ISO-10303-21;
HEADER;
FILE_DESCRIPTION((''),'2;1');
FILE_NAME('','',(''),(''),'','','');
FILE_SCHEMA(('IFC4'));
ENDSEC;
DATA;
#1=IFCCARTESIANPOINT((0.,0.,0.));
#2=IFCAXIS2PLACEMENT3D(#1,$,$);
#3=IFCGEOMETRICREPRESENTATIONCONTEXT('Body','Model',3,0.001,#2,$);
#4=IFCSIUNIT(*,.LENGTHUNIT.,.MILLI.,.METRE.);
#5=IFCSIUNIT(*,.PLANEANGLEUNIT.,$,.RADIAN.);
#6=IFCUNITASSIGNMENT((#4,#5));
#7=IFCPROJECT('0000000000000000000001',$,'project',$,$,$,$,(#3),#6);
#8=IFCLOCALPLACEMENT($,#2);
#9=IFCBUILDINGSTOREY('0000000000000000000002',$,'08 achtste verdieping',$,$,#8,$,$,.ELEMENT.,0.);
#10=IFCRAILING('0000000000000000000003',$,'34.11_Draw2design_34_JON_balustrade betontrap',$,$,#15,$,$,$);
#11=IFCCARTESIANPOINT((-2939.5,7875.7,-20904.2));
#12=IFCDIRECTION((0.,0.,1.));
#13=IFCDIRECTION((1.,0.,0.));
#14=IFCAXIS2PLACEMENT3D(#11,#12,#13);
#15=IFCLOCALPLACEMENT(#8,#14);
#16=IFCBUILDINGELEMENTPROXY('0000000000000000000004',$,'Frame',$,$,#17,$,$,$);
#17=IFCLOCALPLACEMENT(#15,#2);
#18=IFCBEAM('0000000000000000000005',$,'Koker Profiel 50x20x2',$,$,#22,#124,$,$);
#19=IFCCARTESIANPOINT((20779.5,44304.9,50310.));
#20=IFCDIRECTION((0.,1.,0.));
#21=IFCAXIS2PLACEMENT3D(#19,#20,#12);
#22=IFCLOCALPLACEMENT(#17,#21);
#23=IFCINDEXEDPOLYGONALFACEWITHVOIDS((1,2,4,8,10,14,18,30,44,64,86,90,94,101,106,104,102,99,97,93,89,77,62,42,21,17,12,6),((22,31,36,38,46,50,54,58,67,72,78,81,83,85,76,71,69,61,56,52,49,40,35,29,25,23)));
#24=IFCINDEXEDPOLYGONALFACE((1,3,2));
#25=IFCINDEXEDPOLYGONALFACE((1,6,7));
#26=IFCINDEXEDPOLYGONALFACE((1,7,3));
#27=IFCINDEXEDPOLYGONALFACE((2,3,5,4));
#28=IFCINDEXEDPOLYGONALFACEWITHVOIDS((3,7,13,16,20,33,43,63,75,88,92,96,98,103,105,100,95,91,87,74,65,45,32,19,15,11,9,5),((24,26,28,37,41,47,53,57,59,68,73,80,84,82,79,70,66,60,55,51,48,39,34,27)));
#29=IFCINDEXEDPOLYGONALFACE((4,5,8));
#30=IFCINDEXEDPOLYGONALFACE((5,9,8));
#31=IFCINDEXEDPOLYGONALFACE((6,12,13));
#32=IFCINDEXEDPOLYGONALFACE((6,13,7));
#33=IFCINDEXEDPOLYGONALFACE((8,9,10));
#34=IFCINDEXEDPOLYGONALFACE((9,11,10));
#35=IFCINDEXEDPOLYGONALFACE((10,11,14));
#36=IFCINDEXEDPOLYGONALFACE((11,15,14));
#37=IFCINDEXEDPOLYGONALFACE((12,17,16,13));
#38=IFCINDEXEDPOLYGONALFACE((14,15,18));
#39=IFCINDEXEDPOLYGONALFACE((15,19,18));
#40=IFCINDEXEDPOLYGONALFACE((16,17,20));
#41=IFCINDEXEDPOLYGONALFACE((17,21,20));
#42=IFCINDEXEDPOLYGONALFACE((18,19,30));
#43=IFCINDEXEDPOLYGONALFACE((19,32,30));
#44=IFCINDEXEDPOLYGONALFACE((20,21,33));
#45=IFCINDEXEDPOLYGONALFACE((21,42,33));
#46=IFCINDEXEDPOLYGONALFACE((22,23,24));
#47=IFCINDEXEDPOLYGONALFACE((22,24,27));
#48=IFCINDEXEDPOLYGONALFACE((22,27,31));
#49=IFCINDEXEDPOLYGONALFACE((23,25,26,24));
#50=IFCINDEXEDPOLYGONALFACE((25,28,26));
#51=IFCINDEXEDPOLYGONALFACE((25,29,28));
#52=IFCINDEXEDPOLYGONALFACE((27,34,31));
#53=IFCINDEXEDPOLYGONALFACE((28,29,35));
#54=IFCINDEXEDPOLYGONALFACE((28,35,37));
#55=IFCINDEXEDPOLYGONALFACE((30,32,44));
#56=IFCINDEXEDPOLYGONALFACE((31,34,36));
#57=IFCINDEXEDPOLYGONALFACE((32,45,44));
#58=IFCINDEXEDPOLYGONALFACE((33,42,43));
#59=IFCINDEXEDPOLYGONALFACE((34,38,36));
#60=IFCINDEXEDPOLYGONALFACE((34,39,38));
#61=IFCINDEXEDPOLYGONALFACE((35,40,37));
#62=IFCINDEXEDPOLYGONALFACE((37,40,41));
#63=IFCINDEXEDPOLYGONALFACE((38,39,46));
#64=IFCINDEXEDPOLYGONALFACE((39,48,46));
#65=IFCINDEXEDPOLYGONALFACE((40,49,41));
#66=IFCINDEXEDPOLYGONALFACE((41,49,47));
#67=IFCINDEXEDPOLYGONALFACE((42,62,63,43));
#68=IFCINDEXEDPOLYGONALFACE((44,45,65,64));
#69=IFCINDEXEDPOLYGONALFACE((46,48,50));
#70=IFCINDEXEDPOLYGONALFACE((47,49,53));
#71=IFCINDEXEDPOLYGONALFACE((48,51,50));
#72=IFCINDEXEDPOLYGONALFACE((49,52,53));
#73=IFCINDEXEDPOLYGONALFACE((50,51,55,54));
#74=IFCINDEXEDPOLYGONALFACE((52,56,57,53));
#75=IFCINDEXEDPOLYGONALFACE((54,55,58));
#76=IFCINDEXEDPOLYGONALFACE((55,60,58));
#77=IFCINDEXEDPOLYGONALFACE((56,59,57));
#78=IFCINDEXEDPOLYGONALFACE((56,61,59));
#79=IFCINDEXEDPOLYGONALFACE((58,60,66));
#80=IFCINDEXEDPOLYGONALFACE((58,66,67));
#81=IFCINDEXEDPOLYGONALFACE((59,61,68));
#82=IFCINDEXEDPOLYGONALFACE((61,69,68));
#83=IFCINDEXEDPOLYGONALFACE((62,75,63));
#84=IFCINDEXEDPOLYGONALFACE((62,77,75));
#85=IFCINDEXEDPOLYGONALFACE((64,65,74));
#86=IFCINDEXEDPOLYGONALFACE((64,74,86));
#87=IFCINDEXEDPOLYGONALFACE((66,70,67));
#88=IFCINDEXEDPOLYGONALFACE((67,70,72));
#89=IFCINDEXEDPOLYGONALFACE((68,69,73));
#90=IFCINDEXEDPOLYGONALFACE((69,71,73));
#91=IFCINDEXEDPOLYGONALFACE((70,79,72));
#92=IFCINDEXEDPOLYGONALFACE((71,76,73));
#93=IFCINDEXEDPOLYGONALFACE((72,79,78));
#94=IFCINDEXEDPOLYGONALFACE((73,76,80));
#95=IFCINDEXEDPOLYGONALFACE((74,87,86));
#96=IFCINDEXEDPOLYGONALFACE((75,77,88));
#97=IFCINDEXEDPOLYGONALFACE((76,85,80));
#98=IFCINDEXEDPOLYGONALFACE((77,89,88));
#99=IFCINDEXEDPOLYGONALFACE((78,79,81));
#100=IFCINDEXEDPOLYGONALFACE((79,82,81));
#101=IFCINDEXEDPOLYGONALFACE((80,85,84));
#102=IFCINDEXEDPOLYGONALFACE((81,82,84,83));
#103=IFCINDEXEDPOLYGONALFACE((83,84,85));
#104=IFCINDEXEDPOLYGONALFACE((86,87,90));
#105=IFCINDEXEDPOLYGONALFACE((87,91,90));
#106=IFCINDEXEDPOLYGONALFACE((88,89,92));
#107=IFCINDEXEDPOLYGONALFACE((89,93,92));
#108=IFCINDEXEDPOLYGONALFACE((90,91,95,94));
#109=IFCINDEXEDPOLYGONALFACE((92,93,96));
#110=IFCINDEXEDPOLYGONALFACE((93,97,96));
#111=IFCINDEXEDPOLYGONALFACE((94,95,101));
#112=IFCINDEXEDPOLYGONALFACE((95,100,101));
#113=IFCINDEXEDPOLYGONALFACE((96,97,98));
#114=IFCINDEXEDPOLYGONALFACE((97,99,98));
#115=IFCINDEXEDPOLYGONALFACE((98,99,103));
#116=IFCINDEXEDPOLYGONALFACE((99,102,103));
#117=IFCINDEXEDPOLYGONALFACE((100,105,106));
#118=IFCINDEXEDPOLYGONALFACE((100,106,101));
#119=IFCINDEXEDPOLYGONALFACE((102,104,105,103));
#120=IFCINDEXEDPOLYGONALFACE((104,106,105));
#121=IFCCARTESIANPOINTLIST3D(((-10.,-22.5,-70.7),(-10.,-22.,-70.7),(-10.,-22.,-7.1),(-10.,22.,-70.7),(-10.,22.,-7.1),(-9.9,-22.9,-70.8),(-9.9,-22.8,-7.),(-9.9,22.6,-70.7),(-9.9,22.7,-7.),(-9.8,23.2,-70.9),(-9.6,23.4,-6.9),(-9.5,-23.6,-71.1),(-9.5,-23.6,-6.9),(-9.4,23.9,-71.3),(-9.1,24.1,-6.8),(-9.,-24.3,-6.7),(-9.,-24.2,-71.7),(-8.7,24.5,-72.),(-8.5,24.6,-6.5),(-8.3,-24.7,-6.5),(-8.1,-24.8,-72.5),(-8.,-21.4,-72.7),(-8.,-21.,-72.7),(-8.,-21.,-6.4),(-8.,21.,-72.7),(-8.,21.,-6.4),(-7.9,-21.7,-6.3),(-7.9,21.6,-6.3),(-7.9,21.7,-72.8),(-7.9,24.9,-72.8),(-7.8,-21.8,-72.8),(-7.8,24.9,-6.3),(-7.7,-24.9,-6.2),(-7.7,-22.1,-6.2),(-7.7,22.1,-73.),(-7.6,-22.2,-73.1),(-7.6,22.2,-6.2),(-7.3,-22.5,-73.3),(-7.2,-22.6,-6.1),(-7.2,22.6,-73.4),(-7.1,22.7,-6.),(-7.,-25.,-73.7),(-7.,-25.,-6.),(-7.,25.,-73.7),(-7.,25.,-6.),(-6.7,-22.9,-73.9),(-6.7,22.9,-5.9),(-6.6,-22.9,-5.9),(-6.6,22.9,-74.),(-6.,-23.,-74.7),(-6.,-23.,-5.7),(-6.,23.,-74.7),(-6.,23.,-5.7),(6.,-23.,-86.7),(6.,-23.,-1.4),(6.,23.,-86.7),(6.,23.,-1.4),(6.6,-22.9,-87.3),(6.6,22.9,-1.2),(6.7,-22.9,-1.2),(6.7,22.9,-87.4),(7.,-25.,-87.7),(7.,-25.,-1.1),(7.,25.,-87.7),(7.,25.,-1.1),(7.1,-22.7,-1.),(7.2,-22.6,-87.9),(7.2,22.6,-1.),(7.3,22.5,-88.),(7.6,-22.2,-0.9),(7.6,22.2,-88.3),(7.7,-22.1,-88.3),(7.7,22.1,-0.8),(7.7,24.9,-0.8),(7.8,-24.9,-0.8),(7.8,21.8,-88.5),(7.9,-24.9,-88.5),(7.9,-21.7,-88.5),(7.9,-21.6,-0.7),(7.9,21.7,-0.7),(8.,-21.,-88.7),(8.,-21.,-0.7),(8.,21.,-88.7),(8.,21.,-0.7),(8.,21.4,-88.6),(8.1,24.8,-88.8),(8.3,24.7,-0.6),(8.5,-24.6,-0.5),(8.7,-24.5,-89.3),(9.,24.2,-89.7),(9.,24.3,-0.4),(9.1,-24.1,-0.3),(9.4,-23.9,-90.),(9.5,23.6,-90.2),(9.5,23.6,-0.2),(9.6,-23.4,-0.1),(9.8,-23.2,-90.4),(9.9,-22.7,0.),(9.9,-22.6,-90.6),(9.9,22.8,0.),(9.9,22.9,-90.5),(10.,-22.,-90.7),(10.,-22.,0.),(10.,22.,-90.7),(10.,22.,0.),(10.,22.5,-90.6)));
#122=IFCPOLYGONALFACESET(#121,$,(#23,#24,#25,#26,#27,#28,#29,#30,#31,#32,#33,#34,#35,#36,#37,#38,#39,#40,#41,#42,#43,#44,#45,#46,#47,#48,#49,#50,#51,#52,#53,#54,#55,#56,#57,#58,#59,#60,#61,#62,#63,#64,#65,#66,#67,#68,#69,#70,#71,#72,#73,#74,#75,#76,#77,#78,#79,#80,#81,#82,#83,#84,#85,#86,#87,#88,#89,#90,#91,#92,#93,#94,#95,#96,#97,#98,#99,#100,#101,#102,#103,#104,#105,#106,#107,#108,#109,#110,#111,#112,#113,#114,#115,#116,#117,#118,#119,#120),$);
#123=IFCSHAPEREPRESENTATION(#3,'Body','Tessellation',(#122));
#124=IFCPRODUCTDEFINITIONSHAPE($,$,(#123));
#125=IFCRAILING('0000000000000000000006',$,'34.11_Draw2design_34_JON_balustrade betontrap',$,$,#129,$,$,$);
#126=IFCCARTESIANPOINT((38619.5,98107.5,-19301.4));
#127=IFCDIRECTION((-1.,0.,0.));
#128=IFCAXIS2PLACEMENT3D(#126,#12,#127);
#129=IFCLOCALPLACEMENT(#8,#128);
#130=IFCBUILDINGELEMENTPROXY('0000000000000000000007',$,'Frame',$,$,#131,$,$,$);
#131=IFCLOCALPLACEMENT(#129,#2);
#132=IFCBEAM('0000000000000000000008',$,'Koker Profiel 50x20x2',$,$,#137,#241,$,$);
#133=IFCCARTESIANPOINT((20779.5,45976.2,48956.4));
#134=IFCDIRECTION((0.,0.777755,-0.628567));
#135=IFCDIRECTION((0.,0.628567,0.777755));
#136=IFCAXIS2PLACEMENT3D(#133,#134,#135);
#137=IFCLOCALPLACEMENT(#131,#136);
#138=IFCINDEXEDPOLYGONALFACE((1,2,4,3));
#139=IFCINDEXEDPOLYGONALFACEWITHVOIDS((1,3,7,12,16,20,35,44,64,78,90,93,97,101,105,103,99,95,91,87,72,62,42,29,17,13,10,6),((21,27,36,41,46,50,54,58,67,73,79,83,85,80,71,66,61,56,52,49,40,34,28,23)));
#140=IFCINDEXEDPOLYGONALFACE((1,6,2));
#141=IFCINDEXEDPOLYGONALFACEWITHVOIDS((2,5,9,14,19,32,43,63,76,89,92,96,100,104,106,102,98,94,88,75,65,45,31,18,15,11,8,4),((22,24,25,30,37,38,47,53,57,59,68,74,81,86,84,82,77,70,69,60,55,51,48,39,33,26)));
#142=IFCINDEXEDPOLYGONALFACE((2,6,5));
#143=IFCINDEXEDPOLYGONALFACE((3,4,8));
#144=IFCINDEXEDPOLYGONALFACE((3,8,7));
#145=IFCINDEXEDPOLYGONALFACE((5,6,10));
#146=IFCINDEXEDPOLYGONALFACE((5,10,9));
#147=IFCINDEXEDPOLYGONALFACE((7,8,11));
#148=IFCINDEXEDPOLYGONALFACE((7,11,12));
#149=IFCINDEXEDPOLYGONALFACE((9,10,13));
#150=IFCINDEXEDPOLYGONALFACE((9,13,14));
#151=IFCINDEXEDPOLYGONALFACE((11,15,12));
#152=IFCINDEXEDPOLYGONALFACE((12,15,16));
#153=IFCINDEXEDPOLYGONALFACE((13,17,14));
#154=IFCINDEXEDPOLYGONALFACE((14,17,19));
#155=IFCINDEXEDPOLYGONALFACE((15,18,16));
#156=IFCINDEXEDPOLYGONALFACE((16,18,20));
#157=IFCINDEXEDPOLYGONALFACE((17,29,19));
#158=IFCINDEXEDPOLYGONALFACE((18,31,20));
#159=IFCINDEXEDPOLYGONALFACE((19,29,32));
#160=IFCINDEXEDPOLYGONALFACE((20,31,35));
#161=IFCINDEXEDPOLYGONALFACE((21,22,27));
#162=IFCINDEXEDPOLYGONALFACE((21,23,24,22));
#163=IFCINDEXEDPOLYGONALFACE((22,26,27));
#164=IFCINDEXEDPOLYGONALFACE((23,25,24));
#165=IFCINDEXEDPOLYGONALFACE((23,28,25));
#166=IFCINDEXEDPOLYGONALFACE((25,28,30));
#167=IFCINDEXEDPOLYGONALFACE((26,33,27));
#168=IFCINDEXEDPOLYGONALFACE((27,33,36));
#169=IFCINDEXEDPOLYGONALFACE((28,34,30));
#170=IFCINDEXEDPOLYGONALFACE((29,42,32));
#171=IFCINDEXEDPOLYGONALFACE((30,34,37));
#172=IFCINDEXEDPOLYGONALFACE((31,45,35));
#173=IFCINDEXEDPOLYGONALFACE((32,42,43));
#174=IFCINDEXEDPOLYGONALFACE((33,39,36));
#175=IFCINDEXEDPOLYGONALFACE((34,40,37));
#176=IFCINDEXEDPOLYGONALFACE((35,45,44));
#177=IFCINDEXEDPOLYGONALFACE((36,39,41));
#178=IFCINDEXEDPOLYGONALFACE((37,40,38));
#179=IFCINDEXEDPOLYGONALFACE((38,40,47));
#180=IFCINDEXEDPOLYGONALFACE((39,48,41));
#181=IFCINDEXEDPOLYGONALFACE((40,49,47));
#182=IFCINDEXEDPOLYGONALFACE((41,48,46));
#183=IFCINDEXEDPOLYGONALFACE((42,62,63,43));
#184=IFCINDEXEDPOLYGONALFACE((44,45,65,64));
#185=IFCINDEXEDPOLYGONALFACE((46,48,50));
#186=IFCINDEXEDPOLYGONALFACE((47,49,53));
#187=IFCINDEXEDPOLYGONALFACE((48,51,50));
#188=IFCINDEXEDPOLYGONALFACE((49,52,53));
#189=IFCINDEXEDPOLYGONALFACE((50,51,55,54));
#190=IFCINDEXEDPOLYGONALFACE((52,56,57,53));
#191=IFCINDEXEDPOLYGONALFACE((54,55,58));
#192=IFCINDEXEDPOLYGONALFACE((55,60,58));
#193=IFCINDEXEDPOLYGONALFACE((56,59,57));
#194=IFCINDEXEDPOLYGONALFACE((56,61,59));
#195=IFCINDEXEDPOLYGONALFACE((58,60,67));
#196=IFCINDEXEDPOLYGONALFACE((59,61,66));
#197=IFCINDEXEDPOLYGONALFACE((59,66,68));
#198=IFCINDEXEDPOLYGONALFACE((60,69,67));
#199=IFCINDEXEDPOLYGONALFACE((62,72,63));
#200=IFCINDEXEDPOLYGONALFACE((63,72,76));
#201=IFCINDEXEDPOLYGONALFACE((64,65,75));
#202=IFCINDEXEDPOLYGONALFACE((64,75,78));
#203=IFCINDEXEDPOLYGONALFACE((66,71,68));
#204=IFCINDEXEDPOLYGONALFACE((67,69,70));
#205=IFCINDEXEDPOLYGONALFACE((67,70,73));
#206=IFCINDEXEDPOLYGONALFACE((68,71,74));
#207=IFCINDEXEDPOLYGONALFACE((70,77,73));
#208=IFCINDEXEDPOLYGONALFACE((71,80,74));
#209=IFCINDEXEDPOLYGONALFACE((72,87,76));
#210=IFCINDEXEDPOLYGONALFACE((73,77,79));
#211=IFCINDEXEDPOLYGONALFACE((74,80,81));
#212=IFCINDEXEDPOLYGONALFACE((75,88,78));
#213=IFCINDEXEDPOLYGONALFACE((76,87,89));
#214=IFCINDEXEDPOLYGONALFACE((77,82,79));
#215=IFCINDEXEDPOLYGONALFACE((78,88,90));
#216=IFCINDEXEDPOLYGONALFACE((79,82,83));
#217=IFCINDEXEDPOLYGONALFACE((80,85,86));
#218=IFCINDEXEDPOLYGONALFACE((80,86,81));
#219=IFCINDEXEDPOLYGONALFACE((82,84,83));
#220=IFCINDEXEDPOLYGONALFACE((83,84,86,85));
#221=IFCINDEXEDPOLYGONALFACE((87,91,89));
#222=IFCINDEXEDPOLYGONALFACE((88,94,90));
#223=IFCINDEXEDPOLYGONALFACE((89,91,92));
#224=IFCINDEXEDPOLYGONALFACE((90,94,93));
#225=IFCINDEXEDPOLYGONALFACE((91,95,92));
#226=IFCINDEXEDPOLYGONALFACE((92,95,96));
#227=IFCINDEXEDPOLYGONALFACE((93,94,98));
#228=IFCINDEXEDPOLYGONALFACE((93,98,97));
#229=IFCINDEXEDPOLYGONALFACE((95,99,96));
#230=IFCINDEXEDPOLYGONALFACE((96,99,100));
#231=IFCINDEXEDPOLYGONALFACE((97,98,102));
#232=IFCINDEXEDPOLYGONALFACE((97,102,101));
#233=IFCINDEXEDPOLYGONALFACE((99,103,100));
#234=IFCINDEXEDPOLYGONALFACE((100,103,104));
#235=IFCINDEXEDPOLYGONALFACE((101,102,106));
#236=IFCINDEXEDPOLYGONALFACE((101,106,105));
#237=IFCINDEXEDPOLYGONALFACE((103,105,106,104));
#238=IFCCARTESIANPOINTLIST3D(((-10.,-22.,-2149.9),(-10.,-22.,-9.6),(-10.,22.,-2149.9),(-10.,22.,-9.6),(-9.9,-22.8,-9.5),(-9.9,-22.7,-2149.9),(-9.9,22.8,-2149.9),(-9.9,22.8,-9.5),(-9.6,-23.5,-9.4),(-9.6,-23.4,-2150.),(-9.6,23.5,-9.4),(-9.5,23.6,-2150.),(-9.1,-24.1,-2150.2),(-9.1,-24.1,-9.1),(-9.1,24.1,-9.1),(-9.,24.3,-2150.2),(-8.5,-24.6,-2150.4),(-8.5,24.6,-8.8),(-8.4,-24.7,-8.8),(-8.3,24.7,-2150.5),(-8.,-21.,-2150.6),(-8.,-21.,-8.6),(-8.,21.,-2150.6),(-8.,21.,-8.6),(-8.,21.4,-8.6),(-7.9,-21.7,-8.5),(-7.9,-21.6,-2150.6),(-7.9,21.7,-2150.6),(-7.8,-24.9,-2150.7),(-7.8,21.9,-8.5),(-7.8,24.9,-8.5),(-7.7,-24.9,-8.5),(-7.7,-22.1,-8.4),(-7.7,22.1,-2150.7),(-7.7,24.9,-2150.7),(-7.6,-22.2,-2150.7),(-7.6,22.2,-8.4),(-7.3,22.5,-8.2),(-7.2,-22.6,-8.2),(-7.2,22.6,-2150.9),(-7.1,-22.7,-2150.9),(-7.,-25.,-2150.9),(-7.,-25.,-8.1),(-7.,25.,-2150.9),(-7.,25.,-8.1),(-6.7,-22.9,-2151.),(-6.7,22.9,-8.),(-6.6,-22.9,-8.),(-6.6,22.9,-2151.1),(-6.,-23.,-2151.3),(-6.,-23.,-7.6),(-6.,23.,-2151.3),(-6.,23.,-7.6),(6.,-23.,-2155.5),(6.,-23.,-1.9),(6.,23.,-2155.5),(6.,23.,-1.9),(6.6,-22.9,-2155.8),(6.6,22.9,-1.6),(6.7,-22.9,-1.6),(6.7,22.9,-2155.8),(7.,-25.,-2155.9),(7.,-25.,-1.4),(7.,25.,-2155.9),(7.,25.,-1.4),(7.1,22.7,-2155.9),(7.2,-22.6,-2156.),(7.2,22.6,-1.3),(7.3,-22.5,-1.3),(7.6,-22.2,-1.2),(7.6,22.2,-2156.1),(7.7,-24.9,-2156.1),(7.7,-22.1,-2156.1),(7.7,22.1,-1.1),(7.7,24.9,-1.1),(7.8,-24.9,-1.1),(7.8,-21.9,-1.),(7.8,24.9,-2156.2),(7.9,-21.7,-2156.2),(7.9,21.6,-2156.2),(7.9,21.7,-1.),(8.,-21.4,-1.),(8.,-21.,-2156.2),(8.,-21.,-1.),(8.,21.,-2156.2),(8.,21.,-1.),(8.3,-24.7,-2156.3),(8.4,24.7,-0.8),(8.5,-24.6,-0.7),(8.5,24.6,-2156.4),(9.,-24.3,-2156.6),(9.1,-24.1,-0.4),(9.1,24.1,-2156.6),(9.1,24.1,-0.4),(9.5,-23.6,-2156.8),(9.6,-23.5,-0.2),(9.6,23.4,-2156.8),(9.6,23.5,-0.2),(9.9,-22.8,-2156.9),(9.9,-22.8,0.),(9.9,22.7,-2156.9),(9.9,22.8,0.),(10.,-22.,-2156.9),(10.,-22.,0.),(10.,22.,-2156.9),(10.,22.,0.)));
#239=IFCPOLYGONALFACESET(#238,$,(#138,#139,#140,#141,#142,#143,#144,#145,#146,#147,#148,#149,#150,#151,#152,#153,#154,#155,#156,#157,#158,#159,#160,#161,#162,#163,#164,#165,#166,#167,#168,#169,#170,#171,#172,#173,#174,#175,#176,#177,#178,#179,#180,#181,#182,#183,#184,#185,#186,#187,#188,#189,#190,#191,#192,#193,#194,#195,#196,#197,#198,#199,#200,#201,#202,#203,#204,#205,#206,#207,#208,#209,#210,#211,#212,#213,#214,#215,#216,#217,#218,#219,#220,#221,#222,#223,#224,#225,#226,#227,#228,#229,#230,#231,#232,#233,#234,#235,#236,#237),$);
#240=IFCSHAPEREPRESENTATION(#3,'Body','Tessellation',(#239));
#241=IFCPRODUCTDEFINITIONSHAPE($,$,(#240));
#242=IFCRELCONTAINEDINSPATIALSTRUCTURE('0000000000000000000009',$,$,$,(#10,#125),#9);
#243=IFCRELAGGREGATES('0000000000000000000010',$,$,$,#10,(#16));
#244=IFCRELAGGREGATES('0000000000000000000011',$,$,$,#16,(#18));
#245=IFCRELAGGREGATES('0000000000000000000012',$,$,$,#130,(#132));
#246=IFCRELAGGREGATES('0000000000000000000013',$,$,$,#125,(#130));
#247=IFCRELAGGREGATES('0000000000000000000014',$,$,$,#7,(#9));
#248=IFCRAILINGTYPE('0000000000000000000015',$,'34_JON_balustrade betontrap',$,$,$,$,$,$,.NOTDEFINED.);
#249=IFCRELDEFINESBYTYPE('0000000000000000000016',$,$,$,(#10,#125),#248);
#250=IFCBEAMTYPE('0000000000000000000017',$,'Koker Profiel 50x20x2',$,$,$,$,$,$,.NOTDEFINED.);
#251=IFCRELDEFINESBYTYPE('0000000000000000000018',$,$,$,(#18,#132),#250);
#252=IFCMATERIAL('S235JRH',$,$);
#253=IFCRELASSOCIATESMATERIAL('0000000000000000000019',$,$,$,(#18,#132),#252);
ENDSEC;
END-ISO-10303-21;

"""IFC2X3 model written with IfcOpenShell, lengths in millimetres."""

from ifc_helpers import new_model, si_unit, frame, origin, origin_2d, place, context, project, spatial, hollow_rectangle, extrude, clip, halfspace, source, transform, mapped, material, type_object, element, aggregate, save


model = new_model("IFC2X3")

# Units and contexts
model_context = context("Model", 3, precision=0.001, world=origin(), identifier="Body")
ifc_project = project(units=[si_unit("LENGTHUNIT", "METRE", prefix="MILLI"), si_unit("PLANEANGLEUNIT", "RADIAN")], contexts=[model_context])

# Storey
storey_placement = place(None, origin())
storey = spatial("IfcBuildingStorey", under=ifc_project, at=storey_placement, Name="08 achtste verdieping", CompositionType="ELEMENT", Elevation=0.0)

# Railing, building element proxy, beam
railing_type_1 = type_object("IfcRailingType", Name="34_JON_balustrade betontrap")
railing_1_placement = place(storey_placement, frame((-2939.5, 7875.7, -20904.2), z_axis=(0.0, 0.0, 1.0), x_axis=(1.0, 0.0, 0.0)))
railing_1 = element("IfcRailing", 1, at=railing_1_placement, inside=storey, type_object=railing_type_1, Name="34.11_Draw2design_34_JON_balustrade betontrap")
ifc_material_1 = material(Name="S235JRH")
proxy_1_placement = place(railing_1_placement, origin())
proxy_1 = element("IfcBuildingElementProxy", 2, at=proxy_1_placement, Name="Frame")
aggregate(railing_1, [proxy_1])
beam_type_1 = type_object("IfcBeamType", Name="Koker Profiel 50x20x2")
shared_shape_1 = source(origin(), model_context, "Body", "Clipping", [
    clip(clip(extrude(hollow_rectangle(XDim=20.0, YDim=50.0, WallThickness=2.0, InnerFilletRadius=2.0, OuterFilletRadius=3.0, at=origin_2d()), origin(), (0.0, 0.0, -1.0), 90.7), halfspace(frame((-10.0, 25.0, -7.1), z_axis=(-0.33335, 0.0, 0.942803), x_axis=(0.0, 1.0, 0.0)), False)), halfspace(frame((-10.0, -25.0, -70.7), z_axis=(-0.707107, 0.0, -0.707107), x_axis=(0.0, -1.0, 0.0)), False)),
])
beam_1_placement = place(proxy_1_placement, frame((20779.5, 44304.9, 50310.0), z_axis=(0.0, 1.0, 0.0), x_axis=(0.0, 0.0, 1.0)))
beam_1 = element("IfcBeam", 3, at=beam_1_placement, type_object=beam_type_1, material=ifc_material_1, Name="Koker Profiel 50x20x2", context=model_context, shape_type="MappedRepresentation", body=[
    mapped(shared_shape_1, transform((0.0, 0.0, 0.0), scale=1.0)),
])

# Railing, building element proxy, beam
railing_2_placement = place(storey_placement, frame((38619.5, 98107.5, -19301.4), z_axis=(0.0, 0.0, 1.0), x_axis=(-1.0, 0.0, 0.0)))
railing_2 = element("IfcRailing", 4, at=railing_2_placement, inside=storey, type_object=railing_type_1, Name="34.11_Draw2design_34_JON_balustrade betontrap")
proxy_2_placement = place(railing_2_placement, origin())
proxy_2 = element("IfcBuildingElementProxy", 5, at=proxy_2_placement, Name="Frame")
shared_shape_2 = source(origin(), model_context, "Body", "Clipping", [
    clip(clip(extrude(hollow_rectangle(XDim=20.0, YDim=50.0, WallThickness=2.0, InnerFilletRadius=2.0, OuterFilletRadius=3.0, at=origin_2d()), origin(), (0.0, 0.0, -1.0), 2156.9), halfspace(frame((-10.0, 25.0, -9.6), z_axis=(-0.430948, 0.0, 0.902377), x_axis=(-0.902377, 0.0, -0.430948)), False)), halfspace(frame((-10.0, -25.0, -2149.9), z_axis=(-0.33335, 0.0, -0.942803), x_axis=(0.0, -1.0, 0.0)), False)),
])
beam_2_placement = place(proxy_2_placement, frame((20779.5, 45976.2, 48956.4), z_axis=(0.0, 0.777755, -0.628567), x_axis=(0.0, 0.628567, 0.777755)))
beam_2 = element("IfcBeam", 6, at=beam_2_placement, type_object=beam_type_1, material=ifc_material_1, Name="Koker Profiel 50x20x2", context=model_context, shape_type="MappedRepresentation", body=[
    mapped(shared_shape_2, transform((0.0, 0.0, 0.0), scale=1.0)),
])

aggregate(proxy_1, [beam_1])
aggregate(proxy_2, [beam_2])

aggregate(railing_2, [proxy_2])

save(model, "model.ifc")
